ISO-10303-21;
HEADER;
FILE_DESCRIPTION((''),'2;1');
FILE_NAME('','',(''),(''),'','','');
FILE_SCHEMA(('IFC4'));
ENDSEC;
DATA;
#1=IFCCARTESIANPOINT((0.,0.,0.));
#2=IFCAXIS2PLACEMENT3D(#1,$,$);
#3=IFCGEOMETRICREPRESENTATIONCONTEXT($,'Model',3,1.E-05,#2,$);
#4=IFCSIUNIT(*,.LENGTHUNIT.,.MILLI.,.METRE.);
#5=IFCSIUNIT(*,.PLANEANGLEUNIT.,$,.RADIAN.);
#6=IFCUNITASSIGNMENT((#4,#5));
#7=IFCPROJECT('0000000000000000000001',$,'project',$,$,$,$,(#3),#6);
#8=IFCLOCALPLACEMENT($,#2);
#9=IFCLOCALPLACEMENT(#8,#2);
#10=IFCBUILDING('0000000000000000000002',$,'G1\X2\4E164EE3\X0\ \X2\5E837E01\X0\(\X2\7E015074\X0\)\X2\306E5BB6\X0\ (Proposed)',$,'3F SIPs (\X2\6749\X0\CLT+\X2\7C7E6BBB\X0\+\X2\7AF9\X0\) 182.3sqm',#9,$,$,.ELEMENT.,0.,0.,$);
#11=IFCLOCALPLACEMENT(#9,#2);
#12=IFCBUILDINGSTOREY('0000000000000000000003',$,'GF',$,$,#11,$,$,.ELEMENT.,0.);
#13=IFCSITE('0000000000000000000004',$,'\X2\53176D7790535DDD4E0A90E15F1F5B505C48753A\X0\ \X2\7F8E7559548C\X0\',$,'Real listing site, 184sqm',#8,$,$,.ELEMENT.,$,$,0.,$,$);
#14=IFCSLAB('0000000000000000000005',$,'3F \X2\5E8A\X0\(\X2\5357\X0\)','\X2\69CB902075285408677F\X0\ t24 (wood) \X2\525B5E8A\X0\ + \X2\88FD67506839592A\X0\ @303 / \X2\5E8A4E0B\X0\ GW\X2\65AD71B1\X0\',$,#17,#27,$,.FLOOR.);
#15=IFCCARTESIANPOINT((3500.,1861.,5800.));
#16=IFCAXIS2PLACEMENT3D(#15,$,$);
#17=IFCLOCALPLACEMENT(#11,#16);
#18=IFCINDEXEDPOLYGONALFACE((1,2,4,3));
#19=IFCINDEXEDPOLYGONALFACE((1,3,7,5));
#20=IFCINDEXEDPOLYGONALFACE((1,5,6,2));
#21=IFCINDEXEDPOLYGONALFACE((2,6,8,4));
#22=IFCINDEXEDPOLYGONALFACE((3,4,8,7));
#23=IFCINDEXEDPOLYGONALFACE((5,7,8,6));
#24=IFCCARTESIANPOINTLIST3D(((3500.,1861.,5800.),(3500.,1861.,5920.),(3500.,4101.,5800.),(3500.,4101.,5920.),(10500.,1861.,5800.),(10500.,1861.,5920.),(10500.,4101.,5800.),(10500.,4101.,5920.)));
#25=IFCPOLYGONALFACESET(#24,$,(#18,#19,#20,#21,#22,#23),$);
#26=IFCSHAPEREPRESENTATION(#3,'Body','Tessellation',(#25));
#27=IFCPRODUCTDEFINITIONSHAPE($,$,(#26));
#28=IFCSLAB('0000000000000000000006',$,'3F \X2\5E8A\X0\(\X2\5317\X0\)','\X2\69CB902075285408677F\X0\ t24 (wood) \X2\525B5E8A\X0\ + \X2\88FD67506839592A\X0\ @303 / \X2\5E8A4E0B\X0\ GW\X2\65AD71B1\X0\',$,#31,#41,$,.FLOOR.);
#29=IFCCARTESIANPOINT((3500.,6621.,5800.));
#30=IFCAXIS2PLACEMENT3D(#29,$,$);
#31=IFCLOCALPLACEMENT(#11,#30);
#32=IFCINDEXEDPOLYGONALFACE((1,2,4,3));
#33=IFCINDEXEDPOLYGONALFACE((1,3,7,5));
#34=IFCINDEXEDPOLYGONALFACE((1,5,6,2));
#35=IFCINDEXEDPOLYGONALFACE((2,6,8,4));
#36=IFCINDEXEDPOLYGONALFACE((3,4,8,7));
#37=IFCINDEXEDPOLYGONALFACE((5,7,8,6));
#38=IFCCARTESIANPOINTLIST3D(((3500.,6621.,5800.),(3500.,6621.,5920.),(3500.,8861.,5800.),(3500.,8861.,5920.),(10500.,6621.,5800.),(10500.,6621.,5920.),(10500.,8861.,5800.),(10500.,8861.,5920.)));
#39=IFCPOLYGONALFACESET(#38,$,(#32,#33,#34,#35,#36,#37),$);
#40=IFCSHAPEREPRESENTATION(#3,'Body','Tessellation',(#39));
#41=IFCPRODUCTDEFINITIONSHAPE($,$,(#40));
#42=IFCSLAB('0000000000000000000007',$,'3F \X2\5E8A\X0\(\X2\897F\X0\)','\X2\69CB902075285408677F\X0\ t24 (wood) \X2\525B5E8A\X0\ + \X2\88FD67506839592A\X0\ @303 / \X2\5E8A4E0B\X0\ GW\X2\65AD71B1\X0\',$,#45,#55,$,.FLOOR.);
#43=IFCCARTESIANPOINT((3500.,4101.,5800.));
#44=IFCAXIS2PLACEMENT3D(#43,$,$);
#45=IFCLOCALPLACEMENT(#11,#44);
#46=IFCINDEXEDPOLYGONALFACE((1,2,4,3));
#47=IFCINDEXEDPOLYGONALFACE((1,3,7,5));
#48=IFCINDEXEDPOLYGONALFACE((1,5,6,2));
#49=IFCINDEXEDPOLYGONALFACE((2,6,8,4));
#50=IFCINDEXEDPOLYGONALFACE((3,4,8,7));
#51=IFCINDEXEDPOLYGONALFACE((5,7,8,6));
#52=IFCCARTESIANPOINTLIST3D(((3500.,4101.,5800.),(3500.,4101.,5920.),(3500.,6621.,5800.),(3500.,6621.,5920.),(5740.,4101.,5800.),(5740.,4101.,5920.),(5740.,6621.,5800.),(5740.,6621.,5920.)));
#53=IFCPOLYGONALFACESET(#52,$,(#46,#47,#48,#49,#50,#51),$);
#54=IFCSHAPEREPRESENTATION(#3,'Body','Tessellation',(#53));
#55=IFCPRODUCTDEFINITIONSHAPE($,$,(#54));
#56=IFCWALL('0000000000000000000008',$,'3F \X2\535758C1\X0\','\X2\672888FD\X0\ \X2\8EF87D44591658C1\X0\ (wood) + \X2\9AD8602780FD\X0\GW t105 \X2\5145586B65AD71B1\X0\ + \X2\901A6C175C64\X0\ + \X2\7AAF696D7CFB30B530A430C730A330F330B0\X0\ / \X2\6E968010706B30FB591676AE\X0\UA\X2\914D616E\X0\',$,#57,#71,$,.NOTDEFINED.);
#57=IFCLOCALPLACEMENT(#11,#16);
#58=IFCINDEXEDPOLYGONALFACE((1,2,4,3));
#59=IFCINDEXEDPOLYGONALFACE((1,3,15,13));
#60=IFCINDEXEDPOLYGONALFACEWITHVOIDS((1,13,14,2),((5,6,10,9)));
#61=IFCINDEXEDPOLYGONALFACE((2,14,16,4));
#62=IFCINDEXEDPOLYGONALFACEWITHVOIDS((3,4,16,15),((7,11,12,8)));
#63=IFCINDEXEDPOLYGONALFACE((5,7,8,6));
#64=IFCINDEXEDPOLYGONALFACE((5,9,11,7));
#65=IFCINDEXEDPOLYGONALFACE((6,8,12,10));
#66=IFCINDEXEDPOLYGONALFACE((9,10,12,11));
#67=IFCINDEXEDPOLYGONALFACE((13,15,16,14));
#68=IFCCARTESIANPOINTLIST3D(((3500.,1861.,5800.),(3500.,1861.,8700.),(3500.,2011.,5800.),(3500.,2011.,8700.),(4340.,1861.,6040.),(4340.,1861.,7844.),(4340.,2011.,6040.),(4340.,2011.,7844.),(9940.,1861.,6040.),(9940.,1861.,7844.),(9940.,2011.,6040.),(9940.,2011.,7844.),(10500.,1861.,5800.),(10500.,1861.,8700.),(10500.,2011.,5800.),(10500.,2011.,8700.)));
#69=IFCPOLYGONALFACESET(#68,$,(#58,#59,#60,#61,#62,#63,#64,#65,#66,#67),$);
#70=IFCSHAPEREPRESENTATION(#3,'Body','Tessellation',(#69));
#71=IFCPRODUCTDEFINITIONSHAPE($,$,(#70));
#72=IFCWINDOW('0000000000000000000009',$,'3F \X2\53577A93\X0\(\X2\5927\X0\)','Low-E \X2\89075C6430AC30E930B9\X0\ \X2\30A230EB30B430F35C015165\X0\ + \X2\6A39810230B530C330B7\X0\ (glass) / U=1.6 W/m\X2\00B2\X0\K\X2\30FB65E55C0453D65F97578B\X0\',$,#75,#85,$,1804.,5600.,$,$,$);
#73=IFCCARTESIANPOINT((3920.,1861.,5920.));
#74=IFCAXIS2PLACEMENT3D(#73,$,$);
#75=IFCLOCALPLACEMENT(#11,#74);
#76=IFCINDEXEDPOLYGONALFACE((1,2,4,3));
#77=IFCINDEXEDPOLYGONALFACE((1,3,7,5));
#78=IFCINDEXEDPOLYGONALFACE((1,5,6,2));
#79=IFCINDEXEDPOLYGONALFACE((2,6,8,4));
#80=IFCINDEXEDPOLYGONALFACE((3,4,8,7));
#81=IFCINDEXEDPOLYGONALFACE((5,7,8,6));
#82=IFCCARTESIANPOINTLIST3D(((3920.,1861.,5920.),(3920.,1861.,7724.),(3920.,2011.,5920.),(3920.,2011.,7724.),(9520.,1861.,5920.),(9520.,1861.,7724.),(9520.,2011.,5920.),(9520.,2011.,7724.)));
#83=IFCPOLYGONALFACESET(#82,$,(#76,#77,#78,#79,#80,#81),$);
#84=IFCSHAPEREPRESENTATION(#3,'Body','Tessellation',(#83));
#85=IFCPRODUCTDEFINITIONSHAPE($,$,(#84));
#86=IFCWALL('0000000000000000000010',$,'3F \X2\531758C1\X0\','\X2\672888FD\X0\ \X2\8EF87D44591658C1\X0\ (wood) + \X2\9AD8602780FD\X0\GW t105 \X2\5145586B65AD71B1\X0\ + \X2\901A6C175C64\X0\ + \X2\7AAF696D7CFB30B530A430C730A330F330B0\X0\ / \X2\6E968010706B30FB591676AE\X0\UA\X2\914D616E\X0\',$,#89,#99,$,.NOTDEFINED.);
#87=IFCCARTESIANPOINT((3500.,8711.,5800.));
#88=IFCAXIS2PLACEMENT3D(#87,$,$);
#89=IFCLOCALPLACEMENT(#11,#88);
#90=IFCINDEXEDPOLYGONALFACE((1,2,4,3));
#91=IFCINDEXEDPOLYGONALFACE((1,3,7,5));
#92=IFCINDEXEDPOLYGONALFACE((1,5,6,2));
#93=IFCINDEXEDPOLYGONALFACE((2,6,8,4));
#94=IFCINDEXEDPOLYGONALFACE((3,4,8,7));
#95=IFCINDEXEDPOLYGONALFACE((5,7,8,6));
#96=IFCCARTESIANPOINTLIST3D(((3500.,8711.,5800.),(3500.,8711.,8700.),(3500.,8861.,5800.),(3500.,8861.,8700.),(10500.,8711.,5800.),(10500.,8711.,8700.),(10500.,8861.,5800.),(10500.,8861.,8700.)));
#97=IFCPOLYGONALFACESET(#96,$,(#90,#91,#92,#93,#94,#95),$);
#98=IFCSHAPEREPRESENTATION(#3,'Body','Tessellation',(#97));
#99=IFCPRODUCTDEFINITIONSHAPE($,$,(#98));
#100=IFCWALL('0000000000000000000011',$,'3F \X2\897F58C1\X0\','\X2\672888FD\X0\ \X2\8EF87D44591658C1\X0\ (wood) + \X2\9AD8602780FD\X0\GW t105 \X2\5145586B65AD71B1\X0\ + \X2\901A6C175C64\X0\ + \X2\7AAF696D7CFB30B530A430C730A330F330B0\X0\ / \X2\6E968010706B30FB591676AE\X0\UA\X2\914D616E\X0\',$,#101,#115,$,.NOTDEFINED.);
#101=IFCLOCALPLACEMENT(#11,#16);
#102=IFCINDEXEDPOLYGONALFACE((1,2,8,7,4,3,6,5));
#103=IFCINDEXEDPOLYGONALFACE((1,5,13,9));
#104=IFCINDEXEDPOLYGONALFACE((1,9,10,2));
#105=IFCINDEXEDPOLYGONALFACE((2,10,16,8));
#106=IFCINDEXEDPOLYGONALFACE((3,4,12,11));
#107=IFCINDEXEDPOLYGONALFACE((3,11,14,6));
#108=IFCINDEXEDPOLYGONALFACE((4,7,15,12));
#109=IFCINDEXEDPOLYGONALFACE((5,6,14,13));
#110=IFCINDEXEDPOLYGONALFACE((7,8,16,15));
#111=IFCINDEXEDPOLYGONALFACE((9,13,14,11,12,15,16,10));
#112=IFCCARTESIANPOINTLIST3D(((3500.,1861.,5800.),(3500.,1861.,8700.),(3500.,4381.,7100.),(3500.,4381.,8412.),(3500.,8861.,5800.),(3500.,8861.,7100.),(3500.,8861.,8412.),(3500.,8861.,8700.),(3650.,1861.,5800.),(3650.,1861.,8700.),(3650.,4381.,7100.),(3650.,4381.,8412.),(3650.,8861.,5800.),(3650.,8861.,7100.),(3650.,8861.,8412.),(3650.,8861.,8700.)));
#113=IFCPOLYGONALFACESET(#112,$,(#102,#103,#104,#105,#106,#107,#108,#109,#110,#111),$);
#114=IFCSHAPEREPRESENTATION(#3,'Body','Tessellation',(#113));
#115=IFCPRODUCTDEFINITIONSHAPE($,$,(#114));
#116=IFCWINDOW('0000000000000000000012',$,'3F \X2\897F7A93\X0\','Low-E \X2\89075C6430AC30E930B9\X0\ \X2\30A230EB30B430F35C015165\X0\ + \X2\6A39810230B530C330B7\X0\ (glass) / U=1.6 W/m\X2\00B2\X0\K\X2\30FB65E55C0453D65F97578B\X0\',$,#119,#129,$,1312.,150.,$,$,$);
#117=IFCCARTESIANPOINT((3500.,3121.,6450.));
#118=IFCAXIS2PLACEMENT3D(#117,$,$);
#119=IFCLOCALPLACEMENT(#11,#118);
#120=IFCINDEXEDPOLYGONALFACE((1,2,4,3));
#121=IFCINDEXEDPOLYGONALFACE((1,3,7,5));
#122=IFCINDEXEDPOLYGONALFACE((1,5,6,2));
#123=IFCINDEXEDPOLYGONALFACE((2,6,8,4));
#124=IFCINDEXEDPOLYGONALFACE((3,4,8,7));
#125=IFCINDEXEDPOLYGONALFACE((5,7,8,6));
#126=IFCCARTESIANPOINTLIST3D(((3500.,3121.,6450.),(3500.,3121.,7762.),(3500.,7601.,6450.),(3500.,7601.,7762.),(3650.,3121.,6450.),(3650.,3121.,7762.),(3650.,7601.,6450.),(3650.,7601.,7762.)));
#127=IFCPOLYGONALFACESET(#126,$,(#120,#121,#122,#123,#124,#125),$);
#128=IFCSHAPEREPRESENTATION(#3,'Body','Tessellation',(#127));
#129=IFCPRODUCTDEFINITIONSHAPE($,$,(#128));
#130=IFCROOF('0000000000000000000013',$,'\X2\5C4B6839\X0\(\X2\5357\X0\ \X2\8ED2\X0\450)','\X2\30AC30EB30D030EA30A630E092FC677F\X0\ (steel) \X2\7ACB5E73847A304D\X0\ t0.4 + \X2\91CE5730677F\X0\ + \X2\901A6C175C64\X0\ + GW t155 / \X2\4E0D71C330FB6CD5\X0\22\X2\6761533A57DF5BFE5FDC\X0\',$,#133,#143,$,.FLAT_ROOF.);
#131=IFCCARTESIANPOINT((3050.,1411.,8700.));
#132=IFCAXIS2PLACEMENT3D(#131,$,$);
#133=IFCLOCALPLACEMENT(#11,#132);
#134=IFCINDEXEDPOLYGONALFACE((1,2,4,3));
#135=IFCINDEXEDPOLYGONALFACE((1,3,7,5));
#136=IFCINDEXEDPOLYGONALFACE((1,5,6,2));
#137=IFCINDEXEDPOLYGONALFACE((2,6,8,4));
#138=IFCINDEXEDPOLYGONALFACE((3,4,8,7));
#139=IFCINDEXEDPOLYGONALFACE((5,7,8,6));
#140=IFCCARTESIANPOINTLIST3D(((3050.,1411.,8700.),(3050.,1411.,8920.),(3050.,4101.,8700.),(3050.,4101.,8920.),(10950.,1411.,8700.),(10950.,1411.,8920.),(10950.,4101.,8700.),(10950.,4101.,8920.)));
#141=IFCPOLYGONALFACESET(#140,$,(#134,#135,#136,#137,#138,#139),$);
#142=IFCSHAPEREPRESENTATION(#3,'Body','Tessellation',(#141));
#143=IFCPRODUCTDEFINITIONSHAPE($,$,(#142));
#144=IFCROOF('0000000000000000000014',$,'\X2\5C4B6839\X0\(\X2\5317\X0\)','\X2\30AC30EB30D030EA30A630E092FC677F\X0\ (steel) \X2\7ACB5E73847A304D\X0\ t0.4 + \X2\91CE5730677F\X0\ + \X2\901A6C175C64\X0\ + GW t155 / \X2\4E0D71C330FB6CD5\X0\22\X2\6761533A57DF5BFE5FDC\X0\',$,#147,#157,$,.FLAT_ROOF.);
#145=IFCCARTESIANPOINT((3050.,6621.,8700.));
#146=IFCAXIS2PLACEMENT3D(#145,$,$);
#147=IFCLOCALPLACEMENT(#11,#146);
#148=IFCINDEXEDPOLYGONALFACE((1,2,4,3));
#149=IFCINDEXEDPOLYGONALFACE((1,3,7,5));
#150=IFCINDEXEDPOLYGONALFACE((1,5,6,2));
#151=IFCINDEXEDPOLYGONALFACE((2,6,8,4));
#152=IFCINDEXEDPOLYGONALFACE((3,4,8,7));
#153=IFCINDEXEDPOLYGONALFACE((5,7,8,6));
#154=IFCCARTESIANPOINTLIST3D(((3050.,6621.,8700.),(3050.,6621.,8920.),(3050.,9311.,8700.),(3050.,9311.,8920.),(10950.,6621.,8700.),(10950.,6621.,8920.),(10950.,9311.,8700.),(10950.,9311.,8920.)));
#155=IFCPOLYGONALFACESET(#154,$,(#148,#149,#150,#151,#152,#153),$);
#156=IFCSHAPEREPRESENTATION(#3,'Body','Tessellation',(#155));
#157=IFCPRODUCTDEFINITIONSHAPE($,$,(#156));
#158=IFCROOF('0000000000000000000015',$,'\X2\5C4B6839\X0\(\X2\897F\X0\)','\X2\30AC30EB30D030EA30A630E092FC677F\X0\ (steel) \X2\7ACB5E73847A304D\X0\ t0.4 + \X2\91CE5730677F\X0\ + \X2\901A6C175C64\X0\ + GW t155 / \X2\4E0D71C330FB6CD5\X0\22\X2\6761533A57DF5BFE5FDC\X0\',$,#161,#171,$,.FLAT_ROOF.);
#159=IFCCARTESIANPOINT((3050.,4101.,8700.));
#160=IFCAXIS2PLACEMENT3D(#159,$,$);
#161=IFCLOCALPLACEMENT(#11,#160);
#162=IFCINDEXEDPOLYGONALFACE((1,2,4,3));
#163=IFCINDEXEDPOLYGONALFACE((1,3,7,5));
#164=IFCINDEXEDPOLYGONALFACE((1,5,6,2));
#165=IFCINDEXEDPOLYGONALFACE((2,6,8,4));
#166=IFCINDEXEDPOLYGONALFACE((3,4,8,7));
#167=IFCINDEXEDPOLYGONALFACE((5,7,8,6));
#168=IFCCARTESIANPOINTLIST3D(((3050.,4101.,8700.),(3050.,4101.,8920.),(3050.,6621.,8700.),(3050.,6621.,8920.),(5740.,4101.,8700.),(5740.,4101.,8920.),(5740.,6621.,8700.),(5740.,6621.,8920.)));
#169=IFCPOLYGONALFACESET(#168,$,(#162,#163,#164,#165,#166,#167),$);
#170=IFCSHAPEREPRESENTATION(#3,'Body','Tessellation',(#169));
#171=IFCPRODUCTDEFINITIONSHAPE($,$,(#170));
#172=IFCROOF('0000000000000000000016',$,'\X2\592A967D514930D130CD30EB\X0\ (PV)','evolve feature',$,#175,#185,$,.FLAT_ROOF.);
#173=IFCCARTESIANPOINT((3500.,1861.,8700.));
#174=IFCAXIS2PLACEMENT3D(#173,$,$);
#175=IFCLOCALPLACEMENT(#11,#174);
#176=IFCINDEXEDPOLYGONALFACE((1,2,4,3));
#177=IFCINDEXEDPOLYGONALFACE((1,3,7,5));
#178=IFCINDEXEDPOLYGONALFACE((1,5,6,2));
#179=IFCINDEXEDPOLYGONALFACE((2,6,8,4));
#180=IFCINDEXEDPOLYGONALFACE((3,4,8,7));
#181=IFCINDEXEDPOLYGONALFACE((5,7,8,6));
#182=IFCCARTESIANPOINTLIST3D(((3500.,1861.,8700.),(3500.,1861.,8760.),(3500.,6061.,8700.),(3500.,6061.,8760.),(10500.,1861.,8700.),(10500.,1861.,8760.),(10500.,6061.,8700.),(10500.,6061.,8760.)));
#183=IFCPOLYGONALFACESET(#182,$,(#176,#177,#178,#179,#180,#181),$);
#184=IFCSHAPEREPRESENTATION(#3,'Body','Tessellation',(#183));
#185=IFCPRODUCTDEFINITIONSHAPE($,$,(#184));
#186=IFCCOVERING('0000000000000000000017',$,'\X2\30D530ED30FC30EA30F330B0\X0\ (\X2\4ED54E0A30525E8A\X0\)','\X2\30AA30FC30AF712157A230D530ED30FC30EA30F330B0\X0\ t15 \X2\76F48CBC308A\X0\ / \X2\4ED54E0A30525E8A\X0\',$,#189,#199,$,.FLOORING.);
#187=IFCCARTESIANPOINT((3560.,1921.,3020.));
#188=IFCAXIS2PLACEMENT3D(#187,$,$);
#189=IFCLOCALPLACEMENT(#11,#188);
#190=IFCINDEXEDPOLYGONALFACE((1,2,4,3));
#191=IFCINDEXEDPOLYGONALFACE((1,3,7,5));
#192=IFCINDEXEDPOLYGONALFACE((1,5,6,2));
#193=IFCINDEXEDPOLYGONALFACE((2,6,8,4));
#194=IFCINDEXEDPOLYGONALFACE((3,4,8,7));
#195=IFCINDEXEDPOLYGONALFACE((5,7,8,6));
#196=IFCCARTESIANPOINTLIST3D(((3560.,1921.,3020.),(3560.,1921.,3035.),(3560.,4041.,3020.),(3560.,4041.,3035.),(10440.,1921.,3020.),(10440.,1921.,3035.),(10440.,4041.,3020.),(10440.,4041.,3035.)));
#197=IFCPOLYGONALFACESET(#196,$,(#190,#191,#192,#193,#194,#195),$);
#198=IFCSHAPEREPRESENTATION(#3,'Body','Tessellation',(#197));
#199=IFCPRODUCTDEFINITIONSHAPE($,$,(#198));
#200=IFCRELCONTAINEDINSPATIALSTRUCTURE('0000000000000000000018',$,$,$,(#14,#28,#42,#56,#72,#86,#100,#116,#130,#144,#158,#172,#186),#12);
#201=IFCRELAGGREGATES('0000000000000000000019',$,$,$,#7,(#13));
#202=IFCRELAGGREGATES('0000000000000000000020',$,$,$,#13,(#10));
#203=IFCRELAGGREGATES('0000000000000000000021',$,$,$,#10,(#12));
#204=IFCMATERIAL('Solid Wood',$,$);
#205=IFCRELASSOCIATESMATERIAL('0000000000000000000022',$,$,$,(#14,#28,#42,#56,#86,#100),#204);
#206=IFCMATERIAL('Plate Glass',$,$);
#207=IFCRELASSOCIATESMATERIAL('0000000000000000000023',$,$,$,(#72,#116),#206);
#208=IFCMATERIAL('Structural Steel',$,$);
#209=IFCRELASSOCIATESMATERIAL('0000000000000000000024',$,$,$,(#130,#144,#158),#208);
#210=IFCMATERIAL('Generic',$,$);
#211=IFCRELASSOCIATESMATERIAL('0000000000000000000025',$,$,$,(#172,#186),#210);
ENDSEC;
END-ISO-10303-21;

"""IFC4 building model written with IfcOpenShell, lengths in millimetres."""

from ifc_helpers import new_model, si_unit, frame, frame_2d, origin, place, context, project, spatial, rectangle, extrude, material, element, fill, save


model = new_model("IFC4")

# Units and contexts
model_context = context("Model", 3, precision=1e-05, world=origin())
ifc_project = project(units=[si_unit("LENGTHUNIT", "METRE", prefix="MILLI"), si_unit("PLANEANGLEUNIT", "RADIAN")], contexts=[model_context])

# Site, building, storey
site_placement = place(None, origin())
site = spatial("IfcSite", under=ifc_project, at=site_placement, Name="北海道川上郡弟子屈町 美留和", ObjectType="Real listing site, 184sqm", CompositionType="ELEMENT", RefElevation=0.0)
building_placement = place(site_placement, origin())
building = spatial("IfcBuilding", under=site, at=building_placement, Name="G1世代 広縁(縁側)の家 (Proposed)", ObjectType="3F SIPs (杉CLT+籾殻+竹) 182.3sqm", CompositionType="ELEMENT", ElevationOfRefHeight=0.0, ElevationOfTerrain=0.0)
storey_placement = place(building_placement, origin())
storey = spatial("IfcBuildingStorey", under=building, at=storey_placement, Name="GF", CompositionType="ELEMENT", Elevation=0.0)

# Slabs
ifc_material_1 = material(Name="Solid Wood")
slab_1_placement = place(storey_placement, frame((3500.0, 1861.0, 5800.0)))
element("IfcSlab", 1, at=slab_1_placement, inside=storey, material=ifc_material_1, Name="3F 床(南)", Description="構造用合板 t24 (wood) 剛床 + 製材根太 @303 / 床下 GW断熱", PredefinedType="FLOOR", context=model_context, shape_type="SweptSolid", body=[
    extrude(rectangle(XDim=7000.0, YDim=2240.0, at=frame_2d((3500.0, 1120.0))), frame((3500.0, 1861.0, 5800.0)), (0.0, 0.0, 1.0), 120.0),
])
slab_2_placement = place(storey_placement, frame((3500.0, 6621.0, 5800.0)))
element("IfcSlab", 2, at=slab_2_placement, inside=storey, material=ifc_material_1, Name="3F 床(北)", Description="構造用合板 t24 (wood) 剛床 + 製材根太 @303 / 床下 GW断熱", PredefinedType="FLOOR", context=model_context, shape_type="SweptSolid", body=[
    extrude(rectangle(XDim=7000.0, YDim=2240.0, at=frame_2d((3500.0, 1120.0))), frame((3500.0, 6621.0, 5800.0)), (0.0, 0.0, 1.0), 120.0),
])
slab_3_placement = place(storey_placement, frame((3500.0, 4101.0, 5800.0)))
element("IfcSlab", 3, at=slab_3_placement, inside=storey, material=ifc_material_1, Name="3F 床(西)", Description="構造用合板 t24 (wood) 剛床 + 製材根太 @303 / 床下 GW断熱", PredefinedType="FLOOR", context=model_context, shape_type="SweptSolid", body=[
    extrude(rectangle(XDim=2240.0, YDim=2520.0, at=frame_2d((1120.0, 1260.0))), frame((3500.0, 4101.0, 5800.0)), (0.0, 0.0, 1.0), 120.0),
])

# Wall, opening, window
wall_1_placement = place(storey_placement, frame((3500.0, 1861.0, 5800.0)))
wall_1 = element("IfcWall", 4, at=wall_1_placement, inside=storey, material=ifc_material_1, Name="3F 南壁", Description="木製 軸組外壁 (wood) + 高性能GW t105 充填断熱 + 通気層 + 窯業系サイディング / 準耐火・外皮UA配慮", PredefinedType="NOTDEFINED", context=model_context, shape_type="SweptSolid", body=[
    extrude(rectangle(XDim=7000.0, YDim=150.0, at=frame_2d((3500.0, 75.0))), frame((3500.0, 1861.0, 5800.0)), (0.0, 0.0, 1.0), 2900.0),
])
opening_1_placement = place(storey_placement, frame((3920.0, 1861.0, 5920.0)))
opening_1 = element("IfcOpeningElement", 5, at=opening_1_placement, cuts=wall_1, PredefinedType="NOTDEFINED", context=model_context, shape_type="SweptSolid", body=[
    extrude(rectangle(XDim=5600.0, YDim=150.0, at=frame_2d((2800.0, 75.0))), frame((3920.0, 1861.0, 5920.0)), (0.0, 0.0, 1.0), 1804.0),
])
ifc_material_2 = material(Name="Plate Glass")
window_1_placement = place(storey_placement, frame((3920.0, 1861.0, 5920.0)))
window_1 = element("IfcWindow", 6, at=window_1_placement, inside=storey, material=ifc_material_2, Name="3F 南窓(大)", Description="Low-E 複層ガラス アルゴン封入 + 樹脂サッシ (glass) / U=1.6 W/m²K・日射取得型", OverallHeight=1804.0, OverallWidth=5600.0, context=model_context, shape_type="SweptSolid", body=[
    extrude(rectangle(XDim=5600.0, YDim=150.0, at=frame_2d((2800.0, 75.0))), frame((3920.0, 1861.0, 5920.0)), (0.0, 0.0, 1.0), 1804.0),
])
fill(opening_1, window_1)

# Wall
wall_2_placement = place(storey_placement, frame((3500.0, 8711.0, 5800.0)))
element("IfcWall", 7, at=wall_2_placement, inside=storey, material=ifc_material_1, Name="3F 北壁", Description="木製 軸組外壁 (wood) + 高性能GW t105 充填断熱 + 通気層 + 窯業系サイディング / 準耐火・外皮UA配慮", PredefinedType="NOTDEFINED", context=model_context, shape_type="SweptSolid", body=[
    extrude(rectangle(XDim=7000.0, YDim=150.0, at=frame_2d((3500.0, 75.0))), frame((3500.0, 8711.0, 5800.0)), (0.0, 0.0, 1.0), 2900.0),
])

# Wall, opening, window
wall_3_placement = place(storey_placement, frame((3500.0, 1861.0, 5800.0)))
wall_3 = element("IfcWall", 8, at=wall_3_placement, inside=storey, material=ifc_material_1, Name="3F 西壁", Description="木製 軸組外壁 (wood) + 高性能GW t105 充填断熱 + 通気層 + 窯業系サイディング / 準耐火・外皮UA配慮", PredefinedType="NOTDEFINED", context=model_context, shape_type="SweptSolid", body=[
    extrude(rectangle(XDim=150.0, YDim=7000.0, at=frame_2d((75.0, 3500.0))), frame((3500.0, 1861.0, 5800.0)), (0.0, 0.0, 1.0), 2900.0),
])
opening_2_placement = place(storey_placement, frame((3500.0, 3121.0, 6450.0)))
opening_2 = element("IfcOpeningElement", 9, at=opening_2_placement, cuts=wall_3, PredefinedType="NOTDEFINED", context=model_context, shape_type="SweptSolid", body=[
    extrude(rectangle(XDim=150.0, YDim=4480.0, at=frame_2d((75.0, 2240.0))), frame((3500.0, 3121.0, 6450.0)), (0.0, 0.0, 1.0), 1312.0),
])
window_2_placement = place(storey_placement, frame((3500.0, 3121.0, 6450.0)))
window_2 = element("IfcWindow", 10, at=window_2_placement, inside=storey, material=ifc_material_2, Name="3F 西窓", Description="Low-E 複層ガラス アルゴン封入 + 樹脂サッシ (glass) / U=1.6 W/m²K・日射取得型", OverallHeight=1312.0, OverallWidth=150.0, context=model_context, shape_type="SweptSolid", body=[
    extrude(rectangle(XDim=150.0, YDim=4480.0, at=frame_2d((75.0, 2240.0))), frame((3500.0, 3121.0, 6450.0)), (0.0, 0.0, 1.0), 1312.0),
])
fill(opening_2, window_2)

# Roofs
ifc_material_3 = material(Name="Structural Steel")
roof_1_placement = place(storey_placement, frame((3050.0, 1411.0, 8700.0)))
element("IfcRoof", 11, at=roof_1_placement, inside=storey, material=ifc_material_3, Name="屋根(南 軒450)", Description="ガルバリウム鋼板 (steel) 立平葺き t0.4 + 野地板 + 通気層 + GW t155 / 不燃・法22条区域対応", PredefinedType="FLAT_ROOF", context=model_context, shape_type="SweptSolid", body=[
    extrude(rectangle(XDim=7900.0, YDim=2690.0, at=frame_2d((3950.0, 1345.0))), frame((3050.0, 1411.0, 8700.0)), (0.0, 0.0, 1.0), 220.0),
])
roof_2_placement = place(storey_placement, frame((3050.0, 6621.0, 8700.0)))
element("IfcRoof", 12, at=roof_2_placement, inside=storey, material=ifc_material_3, Name="屋根(北)", Description="ガルバリウム鋼板 (steel) 立平葺き t0.4 + 野地板 + 通気層 + GW t155 / 不燃・法22条区域対応", PredefinedType="FLAT_ROOF", context=model_context, shape_type="SweptSolid", body=[
    extrude(rectangle(XDim=7900.0, YDim=2690.0, at=frame_2d((3950.0, 1345.0))), frame((3050.0, 6621.0, 8700.0)), (0.0, 0.0, 1.0), 220.0),
])
roof_3_placement = place(storey_placement, frame((3050.0, 4101.0, 8700.0)))
element("IfcRoof", 13, at=roof_3_placement, inside=storey, material=ifc_material_3, Name="屋根(西)", Description="ガルバリウム鋼板 (steel) 立平葺き t0.4 + 野地板 + 通気層 + GW t155 / 不燃・法22条区域対応", PredefinedType="FLAT_ROOF", context=model_context, shape_type="SweptSolid", body=[
    extrude(rectangle(XDim=2690.0, YDim=2520.0, at=frame_2d((1345.0, 1260.0))), frame((3050.0, 4101.0, 8700.0)), (0.0, 0.0, 1.0), 220.0),
])
ifc_material_4 = material(Name="Generic")
roof_4_placement = place(storey_placement, frame((3500.0, 1861.0, 8700.0)))
element("IfcRoof", 14, at=roof_4_placement, inside=storey, material=ifc_material_4, Name="太陽光パネル (PV)", Description="evolve feature", PredefinedType="FLAT_ROOF", context=model_context, shape_type="SweptSolid", body=[
    extrude(rectangle(XDim=7000.0, YDim=4200.0, at=frame_2d((3500.0, 2100.0))), frame((3500.0, 1861.0, 8700.0)), (0.0, 0.0, 1.0), 60.0),
])

# Covering
covering_1_placement = place(storey_placement, frame((3560.0, 1921.0, 3020.0)))
element("IfcCovering", 15, at=covering_1_placement, inside=storey, material=ifc_material_4, Name="フローリング (仕上げ床)", Description="オーク無垢フローリング t15 直貼り / 仕上げ床", PredefinedType="FLOORING", context=model_context, shape_type="SweptSolid", body=[
    extrude(rectangle(XDim=6880.0, YDim=2120.0, at=frame_2d((3440.0, 1060.0))), frame((3560.0, 1921.0, 3020.0)), (0.0, 0.0, 1.0), 15.0),
])

save(model, "model.ifc")
